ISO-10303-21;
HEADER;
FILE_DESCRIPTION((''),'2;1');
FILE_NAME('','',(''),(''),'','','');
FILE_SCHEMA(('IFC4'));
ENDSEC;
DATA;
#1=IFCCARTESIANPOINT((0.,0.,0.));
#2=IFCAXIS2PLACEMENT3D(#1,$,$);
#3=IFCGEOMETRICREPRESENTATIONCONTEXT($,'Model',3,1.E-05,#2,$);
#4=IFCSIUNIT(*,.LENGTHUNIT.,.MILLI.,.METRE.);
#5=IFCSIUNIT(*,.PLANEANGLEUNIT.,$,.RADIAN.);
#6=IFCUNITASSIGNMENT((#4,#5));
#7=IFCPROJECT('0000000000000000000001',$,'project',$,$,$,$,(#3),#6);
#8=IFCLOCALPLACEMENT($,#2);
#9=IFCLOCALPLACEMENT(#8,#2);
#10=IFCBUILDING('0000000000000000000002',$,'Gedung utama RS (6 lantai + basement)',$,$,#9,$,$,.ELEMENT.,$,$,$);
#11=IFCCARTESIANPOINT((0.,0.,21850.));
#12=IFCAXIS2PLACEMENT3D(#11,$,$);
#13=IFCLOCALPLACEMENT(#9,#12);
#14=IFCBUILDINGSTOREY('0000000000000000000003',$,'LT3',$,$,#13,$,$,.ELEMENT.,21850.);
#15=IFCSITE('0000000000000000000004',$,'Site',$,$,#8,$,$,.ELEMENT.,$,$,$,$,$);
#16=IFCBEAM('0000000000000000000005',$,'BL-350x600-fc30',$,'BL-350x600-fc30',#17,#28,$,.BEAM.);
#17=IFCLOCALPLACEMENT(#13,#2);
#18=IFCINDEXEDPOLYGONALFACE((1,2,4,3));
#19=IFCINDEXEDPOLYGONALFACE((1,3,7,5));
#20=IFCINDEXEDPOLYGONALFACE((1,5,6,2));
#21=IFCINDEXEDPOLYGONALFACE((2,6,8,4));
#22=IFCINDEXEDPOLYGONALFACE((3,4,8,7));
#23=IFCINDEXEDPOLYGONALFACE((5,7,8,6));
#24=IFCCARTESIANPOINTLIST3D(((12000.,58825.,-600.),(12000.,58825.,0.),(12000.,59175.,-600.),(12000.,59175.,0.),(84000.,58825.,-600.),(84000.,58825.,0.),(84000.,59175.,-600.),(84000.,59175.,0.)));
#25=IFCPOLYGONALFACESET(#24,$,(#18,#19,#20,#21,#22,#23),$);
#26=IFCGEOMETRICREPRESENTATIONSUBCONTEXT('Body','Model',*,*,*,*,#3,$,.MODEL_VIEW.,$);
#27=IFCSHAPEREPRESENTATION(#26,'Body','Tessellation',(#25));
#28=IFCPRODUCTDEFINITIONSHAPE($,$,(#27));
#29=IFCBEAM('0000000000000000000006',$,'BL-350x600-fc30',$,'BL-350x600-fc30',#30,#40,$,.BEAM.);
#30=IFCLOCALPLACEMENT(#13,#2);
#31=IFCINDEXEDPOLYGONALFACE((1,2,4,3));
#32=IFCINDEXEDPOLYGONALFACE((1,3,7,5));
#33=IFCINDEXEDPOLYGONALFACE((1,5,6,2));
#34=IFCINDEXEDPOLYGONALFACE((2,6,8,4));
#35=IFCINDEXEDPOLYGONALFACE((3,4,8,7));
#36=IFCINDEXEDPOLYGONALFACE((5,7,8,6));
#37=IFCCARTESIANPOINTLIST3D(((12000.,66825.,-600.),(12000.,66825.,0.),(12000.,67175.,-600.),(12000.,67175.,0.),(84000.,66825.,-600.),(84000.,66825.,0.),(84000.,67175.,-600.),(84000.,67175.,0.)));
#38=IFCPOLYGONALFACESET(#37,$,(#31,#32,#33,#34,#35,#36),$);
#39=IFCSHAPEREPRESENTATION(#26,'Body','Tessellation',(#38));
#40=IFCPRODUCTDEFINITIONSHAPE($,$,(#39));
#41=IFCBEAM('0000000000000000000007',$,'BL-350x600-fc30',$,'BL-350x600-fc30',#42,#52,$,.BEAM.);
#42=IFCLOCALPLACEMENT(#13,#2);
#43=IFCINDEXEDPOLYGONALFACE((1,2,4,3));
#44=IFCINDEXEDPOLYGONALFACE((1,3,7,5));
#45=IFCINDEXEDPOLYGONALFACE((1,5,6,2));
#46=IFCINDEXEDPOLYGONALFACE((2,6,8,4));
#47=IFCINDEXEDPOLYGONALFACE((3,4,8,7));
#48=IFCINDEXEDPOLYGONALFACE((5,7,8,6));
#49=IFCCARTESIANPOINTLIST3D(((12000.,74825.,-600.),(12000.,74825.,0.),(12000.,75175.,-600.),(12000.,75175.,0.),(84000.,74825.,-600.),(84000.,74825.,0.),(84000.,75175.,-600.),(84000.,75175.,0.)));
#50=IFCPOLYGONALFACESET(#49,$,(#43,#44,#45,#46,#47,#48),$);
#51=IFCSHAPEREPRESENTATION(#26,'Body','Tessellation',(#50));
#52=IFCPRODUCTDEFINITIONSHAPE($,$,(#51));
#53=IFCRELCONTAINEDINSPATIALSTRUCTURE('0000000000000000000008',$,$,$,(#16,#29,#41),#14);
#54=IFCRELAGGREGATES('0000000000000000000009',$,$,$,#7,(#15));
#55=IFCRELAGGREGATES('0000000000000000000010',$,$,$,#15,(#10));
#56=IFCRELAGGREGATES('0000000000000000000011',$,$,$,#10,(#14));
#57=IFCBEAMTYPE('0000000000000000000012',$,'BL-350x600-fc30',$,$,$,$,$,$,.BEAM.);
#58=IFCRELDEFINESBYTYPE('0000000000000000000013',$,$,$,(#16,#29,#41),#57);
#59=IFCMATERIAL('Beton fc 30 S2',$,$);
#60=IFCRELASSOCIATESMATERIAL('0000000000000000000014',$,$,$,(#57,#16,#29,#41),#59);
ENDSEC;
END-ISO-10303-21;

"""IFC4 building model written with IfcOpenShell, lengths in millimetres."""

from ifc_helpers import new_model, si_unit, frame, origin, origin_2d, place, context, subcontext, project, spatial, rectangle, extrude, material, material_profile, profile_set, profile_usage, type_object, element, save


model = new_model("IFC4")

# Units and contexts
model_context = context("Model", 3, precision=1e-05, world=origin())
body_context = subcontext(model_context, "Body", "Model", "MODEL_VIEW")
ifc_project = project(units=[si_unit("LENGTHUNIT", "METRE", prefix="MILLI"), si_unit("PLANEANGLEUNIT", "RADIAN")], contexts=[model_context])

# Site, building, storey
site_placement = place(None, origin())
site = spatial("IfcSite", under=ifc_project, at=site_placement, Name="Site", CompositionType="ELEMENT")
building_placement = place(site_placement, origin())
building = spatial("IfcBuilding", under=site, at=building_placement, Name="Gedung utama RS (6 lantai + basement)", CompositionType="ELEMENT")
storey_placement = place(building_placement, frame((0.0, 0.0, 21850.0)))
storey = spatial("IfcBuildingStorey", under=building, at=storey_placement, Name="LT3", CompositionType="ELEMENT", Elevation=21850.0)

# Beams
ifc_material = material(Name="Beton fc 30 S2")
ifc_material_profile_1 = material_profile(ifc_material, rectangle(XDim=350.0, YDim=600.0, at=origin_2d()), Name="BL-350x600-fc30")
ifc_profile_set_1 = profile_set([ifc_material_profile_1], Name="BL-350x600-fc30")
ifc_profile_usage_1 = profile_usage(ifc_profile_set_1, cardinal=8)
beam_type = type_object("IfcBeamType", Name="BL-350x600-fc30", PredefinedType="BEAM", material=ifc_profile_set_1)
for number, where, name in (
    (1, (12000.0, 59000.0, -300.0), "BL-350x600-fc30"),
    (2, (12000.0, 67000.0, -300.0), "BL-350x600-fc30"),
    (3, (12000.0, 75000.0, -300.0), "BL-350x600-fc30"),
):
    element("IfcBeam", number, at=place(storey_placement, frame(where)), inside=storey, type_object=beam_type, material=ifc_profile_usage_1, Name=name, ObjectType="BL-350x600-fc30", PredefinedType="BEAM", context=body_context, shape_type="SweptSolid", body=[
        extrude(rectangle(XDim=350.0, YDim=600.0, at=origin_2d()), frame((0.0, 0.0, 0.0), z_axis=(1.0, 0.0, 0.0), x_axis=(0.0, 1.0, 0.0)), (0.0, 0.0, 1.0), 72000.0),
    ])

save(model, "model.ifc")
